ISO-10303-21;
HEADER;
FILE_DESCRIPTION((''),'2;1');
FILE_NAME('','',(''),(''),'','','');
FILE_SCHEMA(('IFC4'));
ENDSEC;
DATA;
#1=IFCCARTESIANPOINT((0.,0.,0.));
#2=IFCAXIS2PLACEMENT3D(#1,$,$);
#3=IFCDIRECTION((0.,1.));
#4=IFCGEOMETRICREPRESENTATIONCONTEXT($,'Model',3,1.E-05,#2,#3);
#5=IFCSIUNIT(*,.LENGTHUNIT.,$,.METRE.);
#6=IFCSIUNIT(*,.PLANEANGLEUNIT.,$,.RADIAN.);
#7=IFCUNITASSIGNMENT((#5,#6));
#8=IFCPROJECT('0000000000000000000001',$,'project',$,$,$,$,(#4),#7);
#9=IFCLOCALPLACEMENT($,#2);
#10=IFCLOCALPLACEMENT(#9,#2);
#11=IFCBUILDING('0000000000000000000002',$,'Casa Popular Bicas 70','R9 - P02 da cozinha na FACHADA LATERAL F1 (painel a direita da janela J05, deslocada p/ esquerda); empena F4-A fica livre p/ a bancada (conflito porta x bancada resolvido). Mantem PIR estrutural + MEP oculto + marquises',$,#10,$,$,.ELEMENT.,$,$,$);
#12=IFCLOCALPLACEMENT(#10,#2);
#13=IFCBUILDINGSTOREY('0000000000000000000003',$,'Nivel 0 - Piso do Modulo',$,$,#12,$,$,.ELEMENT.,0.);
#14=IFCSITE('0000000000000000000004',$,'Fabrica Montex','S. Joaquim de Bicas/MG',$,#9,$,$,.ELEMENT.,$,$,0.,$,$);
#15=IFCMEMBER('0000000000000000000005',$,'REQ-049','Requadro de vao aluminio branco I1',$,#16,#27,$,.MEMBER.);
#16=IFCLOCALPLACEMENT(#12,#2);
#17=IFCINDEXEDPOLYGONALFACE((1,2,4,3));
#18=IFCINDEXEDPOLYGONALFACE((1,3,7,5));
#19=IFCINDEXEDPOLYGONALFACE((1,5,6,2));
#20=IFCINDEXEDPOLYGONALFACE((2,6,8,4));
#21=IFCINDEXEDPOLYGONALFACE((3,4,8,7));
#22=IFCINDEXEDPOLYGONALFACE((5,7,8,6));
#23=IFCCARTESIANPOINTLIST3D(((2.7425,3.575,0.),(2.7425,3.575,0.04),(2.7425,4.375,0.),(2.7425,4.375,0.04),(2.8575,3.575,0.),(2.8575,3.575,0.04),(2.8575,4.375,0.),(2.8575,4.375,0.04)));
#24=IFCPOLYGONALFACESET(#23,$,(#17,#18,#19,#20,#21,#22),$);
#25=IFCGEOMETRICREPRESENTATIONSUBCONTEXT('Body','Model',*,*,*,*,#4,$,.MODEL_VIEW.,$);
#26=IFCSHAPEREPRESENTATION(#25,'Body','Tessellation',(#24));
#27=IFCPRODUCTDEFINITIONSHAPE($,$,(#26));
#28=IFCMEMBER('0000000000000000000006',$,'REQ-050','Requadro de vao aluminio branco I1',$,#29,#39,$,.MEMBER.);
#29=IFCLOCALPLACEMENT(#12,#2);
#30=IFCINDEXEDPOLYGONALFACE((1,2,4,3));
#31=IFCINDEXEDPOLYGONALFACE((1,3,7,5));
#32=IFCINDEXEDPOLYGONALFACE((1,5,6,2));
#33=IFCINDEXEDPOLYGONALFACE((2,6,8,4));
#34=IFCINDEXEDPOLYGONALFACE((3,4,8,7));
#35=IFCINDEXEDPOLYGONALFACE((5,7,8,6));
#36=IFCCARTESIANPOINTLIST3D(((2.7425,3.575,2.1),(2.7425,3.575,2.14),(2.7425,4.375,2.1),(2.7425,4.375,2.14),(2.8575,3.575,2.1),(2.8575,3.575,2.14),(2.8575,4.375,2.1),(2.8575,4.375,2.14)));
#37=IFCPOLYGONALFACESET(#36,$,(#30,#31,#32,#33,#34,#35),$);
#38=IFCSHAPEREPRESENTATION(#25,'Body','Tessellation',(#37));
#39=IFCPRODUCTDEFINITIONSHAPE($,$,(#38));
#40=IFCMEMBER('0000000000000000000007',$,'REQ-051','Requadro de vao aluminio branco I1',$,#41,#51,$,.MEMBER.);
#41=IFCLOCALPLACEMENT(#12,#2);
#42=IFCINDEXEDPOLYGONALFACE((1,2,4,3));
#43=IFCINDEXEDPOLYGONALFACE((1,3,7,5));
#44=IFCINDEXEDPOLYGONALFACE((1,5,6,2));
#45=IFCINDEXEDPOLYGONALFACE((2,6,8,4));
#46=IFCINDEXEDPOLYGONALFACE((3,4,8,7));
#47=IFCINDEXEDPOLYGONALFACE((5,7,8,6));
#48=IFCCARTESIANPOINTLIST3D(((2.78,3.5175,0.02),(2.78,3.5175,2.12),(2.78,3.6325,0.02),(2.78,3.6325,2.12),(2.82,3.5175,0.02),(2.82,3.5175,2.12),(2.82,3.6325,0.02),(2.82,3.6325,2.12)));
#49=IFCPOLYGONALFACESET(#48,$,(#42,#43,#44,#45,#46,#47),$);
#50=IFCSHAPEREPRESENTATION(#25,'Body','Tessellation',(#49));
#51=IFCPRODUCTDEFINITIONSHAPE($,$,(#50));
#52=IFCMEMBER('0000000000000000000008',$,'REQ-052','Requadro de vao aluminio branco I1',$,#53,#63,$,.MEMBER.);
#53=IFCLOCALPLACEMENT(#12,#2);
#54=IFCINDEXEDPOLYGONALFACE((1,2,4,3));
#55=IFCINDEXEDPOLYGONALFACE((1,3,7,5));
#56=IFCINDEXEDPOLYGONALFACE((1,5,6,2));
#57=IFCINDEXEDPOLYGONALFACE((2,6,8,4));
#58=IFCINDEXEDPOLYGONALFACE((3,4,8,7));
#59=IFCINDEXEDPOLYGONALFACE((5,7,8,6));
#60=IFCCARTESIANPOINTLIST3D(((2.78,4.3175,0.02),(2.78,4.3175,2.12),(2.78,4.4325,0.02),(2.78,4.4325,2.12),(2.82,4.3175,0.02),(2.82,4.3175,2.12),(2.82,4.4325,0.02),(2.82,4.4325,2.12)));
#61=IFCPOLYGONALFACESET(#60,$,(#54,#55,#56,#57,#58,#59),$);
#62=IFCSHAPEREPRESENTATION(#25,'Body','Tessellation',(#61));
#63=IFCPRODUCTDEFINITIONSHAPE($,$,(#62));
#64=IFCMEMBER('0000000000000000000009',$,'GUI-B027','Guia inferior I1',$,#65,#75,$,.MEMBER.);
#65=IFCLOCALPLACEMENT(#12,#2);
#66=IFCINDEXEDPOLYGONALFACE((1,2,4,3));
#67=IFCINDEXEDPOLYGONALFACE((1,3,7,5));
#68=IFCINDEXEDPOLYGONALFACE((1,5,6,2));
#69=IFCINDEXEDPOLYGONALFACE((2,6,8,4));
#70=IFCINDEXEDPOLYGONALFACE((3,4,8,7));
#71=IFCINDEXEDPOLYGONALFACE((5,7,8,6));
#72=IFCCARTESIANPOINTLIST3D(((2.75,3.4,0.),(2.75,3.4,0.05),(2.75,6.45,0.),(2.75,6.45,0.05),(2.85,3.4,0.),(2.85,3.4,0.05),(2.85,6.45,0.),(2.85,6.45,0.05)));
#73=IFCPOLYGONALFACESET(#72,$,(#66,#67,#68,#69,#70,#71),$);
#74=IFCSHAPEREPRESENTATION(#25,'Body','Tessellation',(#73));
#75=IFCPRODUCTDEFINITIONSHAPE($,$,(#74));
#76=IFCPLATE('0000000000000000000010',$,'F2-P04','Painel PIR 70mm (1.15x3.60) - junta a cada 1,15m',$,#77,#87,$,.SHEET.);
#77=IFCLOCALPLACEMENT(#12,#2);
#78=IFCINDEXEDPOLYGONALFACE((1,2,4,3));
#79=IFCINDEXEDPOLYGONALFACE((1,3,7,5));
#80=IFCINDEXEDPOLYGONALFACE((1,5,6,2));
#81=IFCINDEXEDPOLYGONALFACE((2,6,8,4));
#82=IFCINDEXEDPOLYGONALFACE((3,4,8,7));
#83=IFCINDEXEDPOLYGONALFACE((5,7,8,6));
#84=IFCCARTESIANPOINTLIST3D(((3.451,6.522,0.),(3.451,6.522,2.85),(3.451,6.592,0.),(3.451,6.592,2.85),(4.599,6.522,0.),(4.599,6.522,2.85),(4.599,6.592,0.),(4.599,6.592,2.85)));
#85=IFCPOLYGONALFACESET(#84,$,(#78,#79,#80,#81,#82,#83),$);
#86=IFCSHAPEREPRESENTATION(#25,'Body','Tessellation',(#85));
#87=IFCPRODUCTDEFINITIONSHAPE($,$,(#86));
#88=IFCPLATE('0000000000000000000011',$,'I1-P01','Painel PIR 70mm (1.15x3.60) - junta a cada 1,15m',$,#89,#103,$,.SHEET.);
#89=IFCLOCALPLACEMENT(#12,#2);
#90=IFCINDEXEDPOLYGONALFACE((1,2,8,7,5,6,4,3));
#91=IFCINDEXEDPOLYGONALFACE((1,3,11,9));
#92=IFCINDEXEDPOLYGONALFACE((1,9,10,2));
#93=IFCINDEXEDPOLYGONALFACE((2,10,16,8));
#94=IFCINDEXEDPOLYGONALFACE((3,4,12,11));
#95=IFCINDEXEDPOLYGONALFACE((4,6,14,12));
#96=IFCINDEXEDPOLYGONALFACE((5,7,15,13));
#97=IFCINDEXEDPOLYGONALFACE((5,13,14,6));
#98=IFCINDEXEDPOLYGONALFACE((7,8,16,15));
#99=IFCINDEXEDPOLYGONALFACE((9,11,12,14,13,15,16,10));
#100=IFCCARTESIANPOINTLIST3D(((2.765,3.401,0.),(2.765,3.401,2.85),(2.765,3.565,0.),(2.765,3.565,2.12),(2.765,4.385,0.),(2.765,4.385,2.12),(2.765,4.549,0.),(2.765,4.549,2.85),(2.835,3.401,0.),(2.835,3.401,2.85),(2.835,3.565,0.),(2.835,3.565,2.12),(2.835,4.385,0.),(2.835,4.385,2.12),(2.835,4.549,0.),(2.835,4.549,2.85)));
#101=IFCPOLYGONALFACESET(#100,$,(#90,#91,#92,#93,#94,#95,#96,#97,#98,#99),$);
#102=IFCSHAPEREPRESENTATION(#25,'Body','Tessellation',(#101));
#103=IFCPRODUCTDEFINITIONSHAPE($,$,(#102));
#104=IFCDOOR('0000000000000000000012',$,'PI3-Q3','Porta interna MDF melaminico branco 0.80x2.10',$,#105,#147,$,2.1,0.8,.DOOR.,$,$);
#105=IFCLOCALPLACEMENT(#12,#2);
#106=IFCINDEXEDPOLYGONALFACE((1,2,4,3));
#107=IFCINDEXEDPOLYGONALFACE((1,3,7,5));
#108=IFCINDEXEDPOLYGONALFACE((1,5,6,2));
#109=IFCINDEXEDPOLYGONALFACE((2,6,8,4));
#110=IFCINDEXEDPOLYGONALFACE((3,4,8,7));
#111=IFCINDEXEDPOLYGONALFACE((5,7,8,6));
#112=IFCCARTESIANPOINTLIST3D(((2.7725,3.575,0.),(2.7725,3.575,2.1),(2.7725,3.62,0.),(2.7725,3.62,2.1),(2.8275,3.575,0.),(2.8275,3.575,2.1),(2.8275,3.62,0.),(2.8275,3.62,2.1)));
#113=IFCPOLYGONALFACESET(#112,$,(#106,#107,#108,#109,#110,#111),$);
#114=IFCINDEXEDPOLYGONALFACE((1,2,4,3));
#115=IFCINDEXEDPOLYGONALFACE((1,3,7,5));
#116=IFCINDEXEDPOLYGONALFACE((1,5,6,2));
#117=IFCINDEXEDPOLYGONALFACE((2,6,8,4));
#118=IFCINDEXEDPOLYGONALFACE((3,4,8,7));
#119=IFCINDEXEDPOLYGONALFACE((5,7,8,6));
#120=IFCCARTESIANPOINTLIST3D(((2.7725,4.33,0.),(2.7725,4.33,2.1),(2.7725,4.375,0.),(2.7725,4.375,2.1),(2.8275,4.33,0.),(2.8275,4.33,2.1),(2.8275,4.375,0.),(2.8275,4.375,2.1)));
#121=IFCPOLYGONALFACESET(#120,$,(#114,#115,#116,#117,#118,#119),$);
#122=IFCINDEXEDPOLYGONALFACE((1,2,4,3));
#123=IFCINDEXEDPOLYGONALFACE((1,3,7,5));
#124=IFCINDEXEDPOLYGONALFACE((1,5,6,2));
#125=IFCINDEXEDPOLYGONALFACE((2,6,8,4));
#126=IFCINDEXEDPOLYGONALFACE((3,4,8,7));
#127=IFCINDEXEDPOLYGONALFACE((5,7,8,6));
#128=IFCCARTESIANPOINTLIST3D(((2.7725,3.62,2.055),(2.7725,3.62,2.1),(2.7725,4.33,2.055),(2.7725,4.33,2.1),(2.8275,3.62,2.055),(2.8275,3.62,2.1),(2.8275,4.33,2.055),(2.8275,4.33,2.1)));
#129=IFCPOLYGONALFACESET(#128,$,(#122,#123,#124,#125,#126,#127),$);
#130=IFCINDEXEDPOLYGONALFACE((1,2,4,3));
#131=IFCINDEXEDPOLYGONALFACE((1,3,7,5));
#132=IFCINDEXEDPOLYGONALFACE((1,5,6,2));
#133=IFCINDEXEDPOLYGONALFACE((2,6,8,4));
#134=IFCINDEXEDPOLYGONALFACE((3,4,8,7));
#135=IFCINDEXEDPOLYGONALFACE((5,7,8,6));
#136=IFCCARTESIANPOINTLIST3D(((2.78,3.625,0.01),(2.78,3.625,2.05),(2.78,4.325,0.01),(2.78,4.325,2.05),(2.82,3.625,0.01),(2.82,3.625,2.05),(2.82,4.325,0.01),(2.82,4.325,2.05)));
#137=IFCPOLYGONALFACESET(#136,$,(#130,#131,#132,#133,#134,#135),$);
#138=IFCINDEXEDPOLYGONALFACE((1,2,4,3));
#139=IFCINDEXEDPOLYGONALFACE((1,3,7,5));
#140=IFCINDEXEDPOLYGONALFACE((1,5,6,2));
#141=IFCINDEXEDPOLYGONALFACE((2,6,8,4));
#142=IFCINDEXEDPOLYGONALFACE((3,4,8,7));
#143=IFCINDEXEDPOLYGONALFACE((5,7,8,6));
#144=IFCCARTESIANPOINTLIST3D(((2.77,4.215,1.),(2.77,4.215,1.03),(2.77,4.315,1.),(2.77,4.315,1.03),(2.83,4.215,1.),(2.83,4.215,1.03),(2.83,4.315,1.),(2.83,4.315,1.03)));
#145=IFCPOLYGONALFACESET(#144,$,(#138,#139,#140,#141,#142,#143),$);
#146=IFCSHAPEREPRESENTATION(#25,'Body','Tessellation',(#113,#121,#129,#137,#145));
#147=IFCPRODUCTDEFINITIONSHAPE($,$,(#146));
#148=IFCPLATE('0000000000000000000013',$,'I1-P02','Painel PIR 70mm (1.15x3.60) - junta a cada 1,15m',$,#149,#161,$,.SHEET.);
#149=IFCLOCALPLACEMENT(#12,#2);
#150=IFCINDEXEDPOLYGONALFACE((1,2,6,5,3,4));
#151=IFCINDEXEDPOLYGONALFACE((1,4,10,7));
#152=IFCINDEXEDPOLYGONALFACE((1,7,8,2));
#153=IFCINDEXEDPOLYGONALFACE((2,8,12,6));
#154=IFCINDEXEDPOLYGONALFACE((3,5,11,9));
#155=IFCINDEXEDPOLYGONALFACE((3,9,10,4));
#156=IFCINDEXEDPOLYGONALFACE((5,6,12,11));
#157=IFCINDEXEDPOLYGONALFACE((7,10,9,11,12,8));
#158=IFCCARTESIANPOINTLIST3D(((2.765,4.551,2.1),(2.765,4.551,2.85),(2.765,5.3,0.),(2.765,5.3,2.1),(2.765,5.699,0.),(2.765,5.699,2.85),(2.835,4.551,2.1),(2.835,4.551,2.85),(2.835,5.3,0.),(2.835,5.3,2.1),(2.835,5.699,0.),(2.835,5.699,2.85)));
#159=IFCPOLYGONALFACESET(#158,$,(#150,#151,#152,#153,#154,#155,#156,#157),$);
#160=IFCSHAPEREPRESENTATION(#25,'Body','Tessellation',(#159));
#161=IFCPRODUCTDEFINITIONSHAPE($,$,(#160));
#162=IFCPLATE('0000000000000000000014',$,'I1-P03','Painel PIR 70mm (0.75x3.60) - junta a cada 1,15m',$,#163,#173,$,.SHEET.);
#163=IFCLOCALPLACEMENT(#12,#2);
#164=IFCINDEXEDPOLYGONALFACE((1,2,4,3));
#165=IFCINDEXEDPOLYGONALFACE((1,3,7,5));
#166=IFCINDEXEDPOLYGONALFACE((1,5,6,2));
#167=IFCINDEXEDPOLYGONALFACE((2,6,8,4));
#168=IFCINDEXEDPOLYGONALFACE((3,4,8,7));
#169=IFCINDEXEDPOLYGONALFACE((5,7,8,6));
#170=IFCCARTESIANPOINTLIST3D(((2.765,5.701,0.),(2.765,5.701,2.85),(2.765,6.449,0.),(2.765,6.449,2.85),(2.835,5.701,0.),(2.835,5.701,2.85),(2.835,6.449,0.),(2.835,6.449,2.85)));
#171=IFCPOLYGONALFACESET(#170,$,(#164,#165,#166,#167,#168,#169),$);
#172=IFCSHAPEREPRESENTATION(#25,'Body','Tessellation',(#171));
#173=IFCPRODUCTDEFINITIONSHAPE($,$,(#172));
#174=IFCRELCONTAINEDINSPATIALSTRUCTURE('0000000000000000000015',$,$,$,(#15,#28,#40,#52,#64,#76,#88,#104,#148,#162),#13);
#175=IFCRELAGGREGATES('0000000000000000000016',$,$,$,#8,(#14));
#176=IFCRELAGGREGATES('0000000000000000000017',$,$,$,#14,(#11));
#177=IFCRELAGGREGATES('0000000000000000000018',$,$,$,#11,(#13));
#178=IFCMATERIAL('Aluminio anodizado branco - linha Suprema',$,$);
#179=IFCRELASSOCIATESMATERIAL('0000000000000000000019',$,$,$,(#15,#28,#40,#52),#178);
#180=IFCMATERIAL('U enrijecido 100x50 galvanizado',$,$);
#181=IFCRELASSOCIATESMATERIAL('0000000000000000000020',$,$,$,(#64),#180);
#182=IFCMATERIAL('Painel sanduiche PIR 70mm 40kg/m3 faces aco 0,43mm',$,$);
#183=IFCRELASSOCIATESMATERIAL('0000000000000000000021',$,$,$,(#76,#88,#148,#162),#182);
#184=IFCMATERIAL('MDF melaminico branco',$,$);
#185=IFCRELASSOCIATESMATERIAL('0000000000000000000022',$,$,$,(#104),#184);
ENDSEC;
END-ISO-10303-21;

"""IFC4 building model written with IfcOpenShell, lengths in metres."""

from ifc_helpers import new_model, si_unit, direction, frame, frame_2d, origin, origin_2d, place, context, subcontext, project, spatial, rectangle, extrude, material, element, fill, save


model = new_model("IFC4")

# Units and contexts
model_context = context("Model", 3, precision=1e-05, world=origin(), true_north=direction((0.0, 1.0)))
body_context = subcontext(model_context, "Body", "Model", "MODEL_VIEW")
ifc_project = project(units=[si_unit("LENGTHUNIT", "METRE"), si_unit("PLANEANGLEUNIT", "RADIAN")], contexts=[model_context])

# Site, building, storey
site_placement = place(None, origin())
site = spatial("IfcSite", under=ifc_project, at=site_placement, Name="Fabrica Montex", Description="S. Joaquim de Bicas/MG", CompositionType="ELEMENT", RefElevation=0.0)
building_placement = place(site_placement, origin())
building = spatial("IfcBuilding", under=site, at=building_placement, Name="Casa Popular Bicas 70", Description="R9 - P02 da cozinha na FACHADA LATERAL F1 (painel a direita da janela J05, deslocada p/ esquerda); empena F4-A fica livre p/ a bancada (conflito porta x bancada resolvido). Mantem PIR estrutural + MEP oculto + marquises", CompositionType="ELEMENT")
storey_placement = place(building_placement, origin())
storey = spatial("IfcBuildingStorey", under=building, at=storey_placement, Name="Nivel 0 - Piso do Modulo", CompositionType="ELEMENT", Elevation=0.0)

# Members
ifc_material_1 = material(Name="Aluminio anodizado branco - linha Suprema")
for number, where, z_axis, x_axis, name in (
    (1, (2.8, 3.575, 0.02), (0.0, 1.0, 0.0), (0.0, 0.0, 1.0), "REQ-049"),
    (2, (2.8, 3.575, 2.12), (0.0, 1.0, 0.0), (0.0, 0.0, 1.0), "REQ-050"),
):
    element("IfcMember", number, at=place(storey_placement, frame(where, z_axis=z_axis, x_axis=x_axis)), inside=storey, material=ifc_material_1, Name=name, Description="Requadro de vao aluminio branco I1", PredefinedType="MEMBER", context=body_context, shape_type="SweptSolid", body=[
        extrude(rectangle(XDim=0.04, YDim=0.115, at=origin_2d()), origin(), (0.0, 0.0, 1.0), 0.8),
    ])
for number, where, z_axis, x_axis, name in (
    (3, (2.8, 3.575, 0.02), (0.0, 0.0, 1.0), (1.0, 0.0, 0.0), "REQ-051"),
    (4, (2.8, 4.375, 0.02), (0.0, 0.0, 1.0), (1.0, 0.0, 0.0), "REQ-052"),
):
    element("IfcMember", number, at=place(storey_placement, frame(where, z_axis=z_axis, x_axis=x_axis)), inside=storey, material=ifc_material_1, Name=name, Description="Requadro de vao aluminio branco I1", PredefinedType="MEMBER", context=body_context, shape_type="SweptSolid", body=[
        extrude(rectangle(XDim=0.04, YDim=0.115, at=origin_2d()), origin(), (0.0, 0.0, 1.0), 2.1),
    ])
ifc_material_2 = material(Name="U enrijecido 100x50 galvanizado")
member_placement = place(storey_placement, frame((2.8, 3.4, 0.025), z_axis=(0.0, 1.0, 0.0), x_axis=(0.0, 0.0, 1.0)))
element("IfcMember", 5, at=member_placement, inside=storey, material=ifc_material_2, Name="GUI-B027", Description="Guia inferior I1", PredefinedType="MEMBER", context=body_context, shape_type="SweptSolid", body=[
    extrude(rectangle(XDim=0.05, YDim=0.1, at=origin_2d()), origin(), (0.0, 0.0, 1.0), 3.05),
])

# Plate
ifc_material_3 = material(Name="Painel sanduiche PIR 70mm 40kg/m3 faces aco 0,43mm")
plate_1_placement = place(storey_placement, frame((3.451, 6.557, 0.0), x_axis=(1.0, 0.0, 0.0)))
element("IfcPlate", 6, at=plate_1_placement, inside=storey, material=ifc_material_3, Name="F2-P04", Description="Painel PIR 70mm (1.15x3.60) - junta a cada 1,15m", PredefinedType="SHEET", context=body_context, shape_type="SweptSolid", body=[
    extrude(rectangle(XDim=1.148, YDim=0.07, at=frame_2d((0.574, 0.0))), origin(), (0.0, 0.0, 1.0), 2.85),
])

# Plate, opening, door
plate_2_placement = place(storey_placement, frame((2.8, 3.401, 0.0), x_axis=(0.0, 1.0, 0.0)))
plate_2 = element("IfcPlate", 7, at=plate_2_placement, inside=storey, material=ifc_material_3, Name="I1-P01", Description="Painel PIR 70mm (1.15x3.60) - junta a cada 1,15m", PredefinedType="SHEET", context=body_context, shape_type="SweptSolid", body=[
    extrude(rectangle(XDim=1.148, YDim=0.07, at=frame_2d((0.574, 0.0))), origin(), (0.0, 0.0, 1.0), 2.85),
])
opening_1_placement = place(storey_placement, frame((2.8, 3.575, 0.0), x_axis=(0.0, 1.0, 0.0)))
opening_1 = element("IfcOpeningElement", 8, at=opening_1_placement, cuts=plate_2, PredefinedType="OPENING", context=body_context, shape_type="SweptSolid", body=[
    extrude(rectangle(XDim=0.82, YDim=0.3, at=frame_2d((0.4, 0.0))), origin(), (0.0, 0.0, 1.0), 2.12),
])
ifc_material_4 = material(Name="MDF melaminico branco")
door_1_placement = place(storey_placement, frame((2.8, 3.575, 0.0), x_axis=(0.0, 1.0, 0.0)))
door_1 = element("IfcDoor", 9, at=door_1_placement, inside=storey, material=ifc_material_4, Name="PI3-Q3", Description="Porta interna MDF melaminico branco 0.80x2.10", OverallHeight=2.1, OverallWidth=0.8, PredefinedType="DOOR", context=body_context, shape_type="SweptSolid", body=[
    extrude(rectangle(XDim=0.045, YDim=0.055, at=frame_2d((0.0225, 0.0))), origin(), (0.0, 0.0, 1.0), 2.1),
    extrude(rectangle(XDim=0.045, YDim=0.055, at=frame_2d((0.7775, 0.0))), origin(), (0.0, 0.0, 1.0), 2.1),
    extrude(rectangle(XDim=0.71, YDim=0.055, at=frame_2d((0.4, 0.0))), frame((0.0, 0.0, 2.055)), (0.0, 0.0, 1.0), 0.045),
    extrude(rectangle(XDim=0.7, YDim=0.04, at=frame_2d((0.4, 0.0))), frame((0.0, 0.0, 0.01)), (0.0, 0.0, 1.0), 2.04),
    extrude(rectangle(XDim=0.1, YDim=0.06, at=frame_2d((0.69, 0.0))), frame((0.0, 0.0, 1.0)), (0.0, 0.0, 1.0), 0.03),
])
fill(opening_1, door_1)

# Plate, opening
plate_3_placement = place(storey_placement, frame((2.8, 4.551, 0.0), x_axis=(0.0, 1.0, 0.0)))
plate_3 = element("IfcPlate", 10, at=plate_3_placement, inside=storey, material=ifc_material_3, Name="I1-P02", Description="Painel PIR 70mm (1.15x3.60) - junta a cada 1,15m", PredefinedType="SHEET", context=body_context, shape_type="SweptSolid", body=[
    extrude(rectangle(XDim=1.148, YDim=0.07, at=frame_2d((0.574, 0.0))), origin(), (0.0, 0.0, 1.0), 2.85),
])
opening_2_placement = place(storey_placement, frame((2.8, 4.925, 0.0)))
element("IfcOpeningElement", 11, at=opening_2_placement, cuts=plate_3, PredefinedType="OPENING", context=body_context, shape_type="SweptSolid", body=[
    extrude(rectangle(XDim=0.1, YDim=0.75, at=origin_2d()), origin(), (0.0, 0.0, 1.0), 2.1),
])

# Plate
plate_4_placement = place(storey_placement, frame((2.8, 5.701, 0.0), x_axis=(0.0, 1.0, 0.0)))
element("IfcPlate", 12, at=plate_4_placement, inside=storey, material=ifc_material_3, Name="I1-P03", Description="Painel PIR 70mm (0.75x3.60) - junta a cada 1,15m", PredefinedType="SHEET", context=body_context, shape_type="SweptSolid", body=[
    extrude(rectangle(XDim=0.748, YDim=0.07, at=frame_2d((0.374, 0.0))), origin(), (0.0, 0.0, 1.0), 2.85),
])

save(model, "model.ifc")
